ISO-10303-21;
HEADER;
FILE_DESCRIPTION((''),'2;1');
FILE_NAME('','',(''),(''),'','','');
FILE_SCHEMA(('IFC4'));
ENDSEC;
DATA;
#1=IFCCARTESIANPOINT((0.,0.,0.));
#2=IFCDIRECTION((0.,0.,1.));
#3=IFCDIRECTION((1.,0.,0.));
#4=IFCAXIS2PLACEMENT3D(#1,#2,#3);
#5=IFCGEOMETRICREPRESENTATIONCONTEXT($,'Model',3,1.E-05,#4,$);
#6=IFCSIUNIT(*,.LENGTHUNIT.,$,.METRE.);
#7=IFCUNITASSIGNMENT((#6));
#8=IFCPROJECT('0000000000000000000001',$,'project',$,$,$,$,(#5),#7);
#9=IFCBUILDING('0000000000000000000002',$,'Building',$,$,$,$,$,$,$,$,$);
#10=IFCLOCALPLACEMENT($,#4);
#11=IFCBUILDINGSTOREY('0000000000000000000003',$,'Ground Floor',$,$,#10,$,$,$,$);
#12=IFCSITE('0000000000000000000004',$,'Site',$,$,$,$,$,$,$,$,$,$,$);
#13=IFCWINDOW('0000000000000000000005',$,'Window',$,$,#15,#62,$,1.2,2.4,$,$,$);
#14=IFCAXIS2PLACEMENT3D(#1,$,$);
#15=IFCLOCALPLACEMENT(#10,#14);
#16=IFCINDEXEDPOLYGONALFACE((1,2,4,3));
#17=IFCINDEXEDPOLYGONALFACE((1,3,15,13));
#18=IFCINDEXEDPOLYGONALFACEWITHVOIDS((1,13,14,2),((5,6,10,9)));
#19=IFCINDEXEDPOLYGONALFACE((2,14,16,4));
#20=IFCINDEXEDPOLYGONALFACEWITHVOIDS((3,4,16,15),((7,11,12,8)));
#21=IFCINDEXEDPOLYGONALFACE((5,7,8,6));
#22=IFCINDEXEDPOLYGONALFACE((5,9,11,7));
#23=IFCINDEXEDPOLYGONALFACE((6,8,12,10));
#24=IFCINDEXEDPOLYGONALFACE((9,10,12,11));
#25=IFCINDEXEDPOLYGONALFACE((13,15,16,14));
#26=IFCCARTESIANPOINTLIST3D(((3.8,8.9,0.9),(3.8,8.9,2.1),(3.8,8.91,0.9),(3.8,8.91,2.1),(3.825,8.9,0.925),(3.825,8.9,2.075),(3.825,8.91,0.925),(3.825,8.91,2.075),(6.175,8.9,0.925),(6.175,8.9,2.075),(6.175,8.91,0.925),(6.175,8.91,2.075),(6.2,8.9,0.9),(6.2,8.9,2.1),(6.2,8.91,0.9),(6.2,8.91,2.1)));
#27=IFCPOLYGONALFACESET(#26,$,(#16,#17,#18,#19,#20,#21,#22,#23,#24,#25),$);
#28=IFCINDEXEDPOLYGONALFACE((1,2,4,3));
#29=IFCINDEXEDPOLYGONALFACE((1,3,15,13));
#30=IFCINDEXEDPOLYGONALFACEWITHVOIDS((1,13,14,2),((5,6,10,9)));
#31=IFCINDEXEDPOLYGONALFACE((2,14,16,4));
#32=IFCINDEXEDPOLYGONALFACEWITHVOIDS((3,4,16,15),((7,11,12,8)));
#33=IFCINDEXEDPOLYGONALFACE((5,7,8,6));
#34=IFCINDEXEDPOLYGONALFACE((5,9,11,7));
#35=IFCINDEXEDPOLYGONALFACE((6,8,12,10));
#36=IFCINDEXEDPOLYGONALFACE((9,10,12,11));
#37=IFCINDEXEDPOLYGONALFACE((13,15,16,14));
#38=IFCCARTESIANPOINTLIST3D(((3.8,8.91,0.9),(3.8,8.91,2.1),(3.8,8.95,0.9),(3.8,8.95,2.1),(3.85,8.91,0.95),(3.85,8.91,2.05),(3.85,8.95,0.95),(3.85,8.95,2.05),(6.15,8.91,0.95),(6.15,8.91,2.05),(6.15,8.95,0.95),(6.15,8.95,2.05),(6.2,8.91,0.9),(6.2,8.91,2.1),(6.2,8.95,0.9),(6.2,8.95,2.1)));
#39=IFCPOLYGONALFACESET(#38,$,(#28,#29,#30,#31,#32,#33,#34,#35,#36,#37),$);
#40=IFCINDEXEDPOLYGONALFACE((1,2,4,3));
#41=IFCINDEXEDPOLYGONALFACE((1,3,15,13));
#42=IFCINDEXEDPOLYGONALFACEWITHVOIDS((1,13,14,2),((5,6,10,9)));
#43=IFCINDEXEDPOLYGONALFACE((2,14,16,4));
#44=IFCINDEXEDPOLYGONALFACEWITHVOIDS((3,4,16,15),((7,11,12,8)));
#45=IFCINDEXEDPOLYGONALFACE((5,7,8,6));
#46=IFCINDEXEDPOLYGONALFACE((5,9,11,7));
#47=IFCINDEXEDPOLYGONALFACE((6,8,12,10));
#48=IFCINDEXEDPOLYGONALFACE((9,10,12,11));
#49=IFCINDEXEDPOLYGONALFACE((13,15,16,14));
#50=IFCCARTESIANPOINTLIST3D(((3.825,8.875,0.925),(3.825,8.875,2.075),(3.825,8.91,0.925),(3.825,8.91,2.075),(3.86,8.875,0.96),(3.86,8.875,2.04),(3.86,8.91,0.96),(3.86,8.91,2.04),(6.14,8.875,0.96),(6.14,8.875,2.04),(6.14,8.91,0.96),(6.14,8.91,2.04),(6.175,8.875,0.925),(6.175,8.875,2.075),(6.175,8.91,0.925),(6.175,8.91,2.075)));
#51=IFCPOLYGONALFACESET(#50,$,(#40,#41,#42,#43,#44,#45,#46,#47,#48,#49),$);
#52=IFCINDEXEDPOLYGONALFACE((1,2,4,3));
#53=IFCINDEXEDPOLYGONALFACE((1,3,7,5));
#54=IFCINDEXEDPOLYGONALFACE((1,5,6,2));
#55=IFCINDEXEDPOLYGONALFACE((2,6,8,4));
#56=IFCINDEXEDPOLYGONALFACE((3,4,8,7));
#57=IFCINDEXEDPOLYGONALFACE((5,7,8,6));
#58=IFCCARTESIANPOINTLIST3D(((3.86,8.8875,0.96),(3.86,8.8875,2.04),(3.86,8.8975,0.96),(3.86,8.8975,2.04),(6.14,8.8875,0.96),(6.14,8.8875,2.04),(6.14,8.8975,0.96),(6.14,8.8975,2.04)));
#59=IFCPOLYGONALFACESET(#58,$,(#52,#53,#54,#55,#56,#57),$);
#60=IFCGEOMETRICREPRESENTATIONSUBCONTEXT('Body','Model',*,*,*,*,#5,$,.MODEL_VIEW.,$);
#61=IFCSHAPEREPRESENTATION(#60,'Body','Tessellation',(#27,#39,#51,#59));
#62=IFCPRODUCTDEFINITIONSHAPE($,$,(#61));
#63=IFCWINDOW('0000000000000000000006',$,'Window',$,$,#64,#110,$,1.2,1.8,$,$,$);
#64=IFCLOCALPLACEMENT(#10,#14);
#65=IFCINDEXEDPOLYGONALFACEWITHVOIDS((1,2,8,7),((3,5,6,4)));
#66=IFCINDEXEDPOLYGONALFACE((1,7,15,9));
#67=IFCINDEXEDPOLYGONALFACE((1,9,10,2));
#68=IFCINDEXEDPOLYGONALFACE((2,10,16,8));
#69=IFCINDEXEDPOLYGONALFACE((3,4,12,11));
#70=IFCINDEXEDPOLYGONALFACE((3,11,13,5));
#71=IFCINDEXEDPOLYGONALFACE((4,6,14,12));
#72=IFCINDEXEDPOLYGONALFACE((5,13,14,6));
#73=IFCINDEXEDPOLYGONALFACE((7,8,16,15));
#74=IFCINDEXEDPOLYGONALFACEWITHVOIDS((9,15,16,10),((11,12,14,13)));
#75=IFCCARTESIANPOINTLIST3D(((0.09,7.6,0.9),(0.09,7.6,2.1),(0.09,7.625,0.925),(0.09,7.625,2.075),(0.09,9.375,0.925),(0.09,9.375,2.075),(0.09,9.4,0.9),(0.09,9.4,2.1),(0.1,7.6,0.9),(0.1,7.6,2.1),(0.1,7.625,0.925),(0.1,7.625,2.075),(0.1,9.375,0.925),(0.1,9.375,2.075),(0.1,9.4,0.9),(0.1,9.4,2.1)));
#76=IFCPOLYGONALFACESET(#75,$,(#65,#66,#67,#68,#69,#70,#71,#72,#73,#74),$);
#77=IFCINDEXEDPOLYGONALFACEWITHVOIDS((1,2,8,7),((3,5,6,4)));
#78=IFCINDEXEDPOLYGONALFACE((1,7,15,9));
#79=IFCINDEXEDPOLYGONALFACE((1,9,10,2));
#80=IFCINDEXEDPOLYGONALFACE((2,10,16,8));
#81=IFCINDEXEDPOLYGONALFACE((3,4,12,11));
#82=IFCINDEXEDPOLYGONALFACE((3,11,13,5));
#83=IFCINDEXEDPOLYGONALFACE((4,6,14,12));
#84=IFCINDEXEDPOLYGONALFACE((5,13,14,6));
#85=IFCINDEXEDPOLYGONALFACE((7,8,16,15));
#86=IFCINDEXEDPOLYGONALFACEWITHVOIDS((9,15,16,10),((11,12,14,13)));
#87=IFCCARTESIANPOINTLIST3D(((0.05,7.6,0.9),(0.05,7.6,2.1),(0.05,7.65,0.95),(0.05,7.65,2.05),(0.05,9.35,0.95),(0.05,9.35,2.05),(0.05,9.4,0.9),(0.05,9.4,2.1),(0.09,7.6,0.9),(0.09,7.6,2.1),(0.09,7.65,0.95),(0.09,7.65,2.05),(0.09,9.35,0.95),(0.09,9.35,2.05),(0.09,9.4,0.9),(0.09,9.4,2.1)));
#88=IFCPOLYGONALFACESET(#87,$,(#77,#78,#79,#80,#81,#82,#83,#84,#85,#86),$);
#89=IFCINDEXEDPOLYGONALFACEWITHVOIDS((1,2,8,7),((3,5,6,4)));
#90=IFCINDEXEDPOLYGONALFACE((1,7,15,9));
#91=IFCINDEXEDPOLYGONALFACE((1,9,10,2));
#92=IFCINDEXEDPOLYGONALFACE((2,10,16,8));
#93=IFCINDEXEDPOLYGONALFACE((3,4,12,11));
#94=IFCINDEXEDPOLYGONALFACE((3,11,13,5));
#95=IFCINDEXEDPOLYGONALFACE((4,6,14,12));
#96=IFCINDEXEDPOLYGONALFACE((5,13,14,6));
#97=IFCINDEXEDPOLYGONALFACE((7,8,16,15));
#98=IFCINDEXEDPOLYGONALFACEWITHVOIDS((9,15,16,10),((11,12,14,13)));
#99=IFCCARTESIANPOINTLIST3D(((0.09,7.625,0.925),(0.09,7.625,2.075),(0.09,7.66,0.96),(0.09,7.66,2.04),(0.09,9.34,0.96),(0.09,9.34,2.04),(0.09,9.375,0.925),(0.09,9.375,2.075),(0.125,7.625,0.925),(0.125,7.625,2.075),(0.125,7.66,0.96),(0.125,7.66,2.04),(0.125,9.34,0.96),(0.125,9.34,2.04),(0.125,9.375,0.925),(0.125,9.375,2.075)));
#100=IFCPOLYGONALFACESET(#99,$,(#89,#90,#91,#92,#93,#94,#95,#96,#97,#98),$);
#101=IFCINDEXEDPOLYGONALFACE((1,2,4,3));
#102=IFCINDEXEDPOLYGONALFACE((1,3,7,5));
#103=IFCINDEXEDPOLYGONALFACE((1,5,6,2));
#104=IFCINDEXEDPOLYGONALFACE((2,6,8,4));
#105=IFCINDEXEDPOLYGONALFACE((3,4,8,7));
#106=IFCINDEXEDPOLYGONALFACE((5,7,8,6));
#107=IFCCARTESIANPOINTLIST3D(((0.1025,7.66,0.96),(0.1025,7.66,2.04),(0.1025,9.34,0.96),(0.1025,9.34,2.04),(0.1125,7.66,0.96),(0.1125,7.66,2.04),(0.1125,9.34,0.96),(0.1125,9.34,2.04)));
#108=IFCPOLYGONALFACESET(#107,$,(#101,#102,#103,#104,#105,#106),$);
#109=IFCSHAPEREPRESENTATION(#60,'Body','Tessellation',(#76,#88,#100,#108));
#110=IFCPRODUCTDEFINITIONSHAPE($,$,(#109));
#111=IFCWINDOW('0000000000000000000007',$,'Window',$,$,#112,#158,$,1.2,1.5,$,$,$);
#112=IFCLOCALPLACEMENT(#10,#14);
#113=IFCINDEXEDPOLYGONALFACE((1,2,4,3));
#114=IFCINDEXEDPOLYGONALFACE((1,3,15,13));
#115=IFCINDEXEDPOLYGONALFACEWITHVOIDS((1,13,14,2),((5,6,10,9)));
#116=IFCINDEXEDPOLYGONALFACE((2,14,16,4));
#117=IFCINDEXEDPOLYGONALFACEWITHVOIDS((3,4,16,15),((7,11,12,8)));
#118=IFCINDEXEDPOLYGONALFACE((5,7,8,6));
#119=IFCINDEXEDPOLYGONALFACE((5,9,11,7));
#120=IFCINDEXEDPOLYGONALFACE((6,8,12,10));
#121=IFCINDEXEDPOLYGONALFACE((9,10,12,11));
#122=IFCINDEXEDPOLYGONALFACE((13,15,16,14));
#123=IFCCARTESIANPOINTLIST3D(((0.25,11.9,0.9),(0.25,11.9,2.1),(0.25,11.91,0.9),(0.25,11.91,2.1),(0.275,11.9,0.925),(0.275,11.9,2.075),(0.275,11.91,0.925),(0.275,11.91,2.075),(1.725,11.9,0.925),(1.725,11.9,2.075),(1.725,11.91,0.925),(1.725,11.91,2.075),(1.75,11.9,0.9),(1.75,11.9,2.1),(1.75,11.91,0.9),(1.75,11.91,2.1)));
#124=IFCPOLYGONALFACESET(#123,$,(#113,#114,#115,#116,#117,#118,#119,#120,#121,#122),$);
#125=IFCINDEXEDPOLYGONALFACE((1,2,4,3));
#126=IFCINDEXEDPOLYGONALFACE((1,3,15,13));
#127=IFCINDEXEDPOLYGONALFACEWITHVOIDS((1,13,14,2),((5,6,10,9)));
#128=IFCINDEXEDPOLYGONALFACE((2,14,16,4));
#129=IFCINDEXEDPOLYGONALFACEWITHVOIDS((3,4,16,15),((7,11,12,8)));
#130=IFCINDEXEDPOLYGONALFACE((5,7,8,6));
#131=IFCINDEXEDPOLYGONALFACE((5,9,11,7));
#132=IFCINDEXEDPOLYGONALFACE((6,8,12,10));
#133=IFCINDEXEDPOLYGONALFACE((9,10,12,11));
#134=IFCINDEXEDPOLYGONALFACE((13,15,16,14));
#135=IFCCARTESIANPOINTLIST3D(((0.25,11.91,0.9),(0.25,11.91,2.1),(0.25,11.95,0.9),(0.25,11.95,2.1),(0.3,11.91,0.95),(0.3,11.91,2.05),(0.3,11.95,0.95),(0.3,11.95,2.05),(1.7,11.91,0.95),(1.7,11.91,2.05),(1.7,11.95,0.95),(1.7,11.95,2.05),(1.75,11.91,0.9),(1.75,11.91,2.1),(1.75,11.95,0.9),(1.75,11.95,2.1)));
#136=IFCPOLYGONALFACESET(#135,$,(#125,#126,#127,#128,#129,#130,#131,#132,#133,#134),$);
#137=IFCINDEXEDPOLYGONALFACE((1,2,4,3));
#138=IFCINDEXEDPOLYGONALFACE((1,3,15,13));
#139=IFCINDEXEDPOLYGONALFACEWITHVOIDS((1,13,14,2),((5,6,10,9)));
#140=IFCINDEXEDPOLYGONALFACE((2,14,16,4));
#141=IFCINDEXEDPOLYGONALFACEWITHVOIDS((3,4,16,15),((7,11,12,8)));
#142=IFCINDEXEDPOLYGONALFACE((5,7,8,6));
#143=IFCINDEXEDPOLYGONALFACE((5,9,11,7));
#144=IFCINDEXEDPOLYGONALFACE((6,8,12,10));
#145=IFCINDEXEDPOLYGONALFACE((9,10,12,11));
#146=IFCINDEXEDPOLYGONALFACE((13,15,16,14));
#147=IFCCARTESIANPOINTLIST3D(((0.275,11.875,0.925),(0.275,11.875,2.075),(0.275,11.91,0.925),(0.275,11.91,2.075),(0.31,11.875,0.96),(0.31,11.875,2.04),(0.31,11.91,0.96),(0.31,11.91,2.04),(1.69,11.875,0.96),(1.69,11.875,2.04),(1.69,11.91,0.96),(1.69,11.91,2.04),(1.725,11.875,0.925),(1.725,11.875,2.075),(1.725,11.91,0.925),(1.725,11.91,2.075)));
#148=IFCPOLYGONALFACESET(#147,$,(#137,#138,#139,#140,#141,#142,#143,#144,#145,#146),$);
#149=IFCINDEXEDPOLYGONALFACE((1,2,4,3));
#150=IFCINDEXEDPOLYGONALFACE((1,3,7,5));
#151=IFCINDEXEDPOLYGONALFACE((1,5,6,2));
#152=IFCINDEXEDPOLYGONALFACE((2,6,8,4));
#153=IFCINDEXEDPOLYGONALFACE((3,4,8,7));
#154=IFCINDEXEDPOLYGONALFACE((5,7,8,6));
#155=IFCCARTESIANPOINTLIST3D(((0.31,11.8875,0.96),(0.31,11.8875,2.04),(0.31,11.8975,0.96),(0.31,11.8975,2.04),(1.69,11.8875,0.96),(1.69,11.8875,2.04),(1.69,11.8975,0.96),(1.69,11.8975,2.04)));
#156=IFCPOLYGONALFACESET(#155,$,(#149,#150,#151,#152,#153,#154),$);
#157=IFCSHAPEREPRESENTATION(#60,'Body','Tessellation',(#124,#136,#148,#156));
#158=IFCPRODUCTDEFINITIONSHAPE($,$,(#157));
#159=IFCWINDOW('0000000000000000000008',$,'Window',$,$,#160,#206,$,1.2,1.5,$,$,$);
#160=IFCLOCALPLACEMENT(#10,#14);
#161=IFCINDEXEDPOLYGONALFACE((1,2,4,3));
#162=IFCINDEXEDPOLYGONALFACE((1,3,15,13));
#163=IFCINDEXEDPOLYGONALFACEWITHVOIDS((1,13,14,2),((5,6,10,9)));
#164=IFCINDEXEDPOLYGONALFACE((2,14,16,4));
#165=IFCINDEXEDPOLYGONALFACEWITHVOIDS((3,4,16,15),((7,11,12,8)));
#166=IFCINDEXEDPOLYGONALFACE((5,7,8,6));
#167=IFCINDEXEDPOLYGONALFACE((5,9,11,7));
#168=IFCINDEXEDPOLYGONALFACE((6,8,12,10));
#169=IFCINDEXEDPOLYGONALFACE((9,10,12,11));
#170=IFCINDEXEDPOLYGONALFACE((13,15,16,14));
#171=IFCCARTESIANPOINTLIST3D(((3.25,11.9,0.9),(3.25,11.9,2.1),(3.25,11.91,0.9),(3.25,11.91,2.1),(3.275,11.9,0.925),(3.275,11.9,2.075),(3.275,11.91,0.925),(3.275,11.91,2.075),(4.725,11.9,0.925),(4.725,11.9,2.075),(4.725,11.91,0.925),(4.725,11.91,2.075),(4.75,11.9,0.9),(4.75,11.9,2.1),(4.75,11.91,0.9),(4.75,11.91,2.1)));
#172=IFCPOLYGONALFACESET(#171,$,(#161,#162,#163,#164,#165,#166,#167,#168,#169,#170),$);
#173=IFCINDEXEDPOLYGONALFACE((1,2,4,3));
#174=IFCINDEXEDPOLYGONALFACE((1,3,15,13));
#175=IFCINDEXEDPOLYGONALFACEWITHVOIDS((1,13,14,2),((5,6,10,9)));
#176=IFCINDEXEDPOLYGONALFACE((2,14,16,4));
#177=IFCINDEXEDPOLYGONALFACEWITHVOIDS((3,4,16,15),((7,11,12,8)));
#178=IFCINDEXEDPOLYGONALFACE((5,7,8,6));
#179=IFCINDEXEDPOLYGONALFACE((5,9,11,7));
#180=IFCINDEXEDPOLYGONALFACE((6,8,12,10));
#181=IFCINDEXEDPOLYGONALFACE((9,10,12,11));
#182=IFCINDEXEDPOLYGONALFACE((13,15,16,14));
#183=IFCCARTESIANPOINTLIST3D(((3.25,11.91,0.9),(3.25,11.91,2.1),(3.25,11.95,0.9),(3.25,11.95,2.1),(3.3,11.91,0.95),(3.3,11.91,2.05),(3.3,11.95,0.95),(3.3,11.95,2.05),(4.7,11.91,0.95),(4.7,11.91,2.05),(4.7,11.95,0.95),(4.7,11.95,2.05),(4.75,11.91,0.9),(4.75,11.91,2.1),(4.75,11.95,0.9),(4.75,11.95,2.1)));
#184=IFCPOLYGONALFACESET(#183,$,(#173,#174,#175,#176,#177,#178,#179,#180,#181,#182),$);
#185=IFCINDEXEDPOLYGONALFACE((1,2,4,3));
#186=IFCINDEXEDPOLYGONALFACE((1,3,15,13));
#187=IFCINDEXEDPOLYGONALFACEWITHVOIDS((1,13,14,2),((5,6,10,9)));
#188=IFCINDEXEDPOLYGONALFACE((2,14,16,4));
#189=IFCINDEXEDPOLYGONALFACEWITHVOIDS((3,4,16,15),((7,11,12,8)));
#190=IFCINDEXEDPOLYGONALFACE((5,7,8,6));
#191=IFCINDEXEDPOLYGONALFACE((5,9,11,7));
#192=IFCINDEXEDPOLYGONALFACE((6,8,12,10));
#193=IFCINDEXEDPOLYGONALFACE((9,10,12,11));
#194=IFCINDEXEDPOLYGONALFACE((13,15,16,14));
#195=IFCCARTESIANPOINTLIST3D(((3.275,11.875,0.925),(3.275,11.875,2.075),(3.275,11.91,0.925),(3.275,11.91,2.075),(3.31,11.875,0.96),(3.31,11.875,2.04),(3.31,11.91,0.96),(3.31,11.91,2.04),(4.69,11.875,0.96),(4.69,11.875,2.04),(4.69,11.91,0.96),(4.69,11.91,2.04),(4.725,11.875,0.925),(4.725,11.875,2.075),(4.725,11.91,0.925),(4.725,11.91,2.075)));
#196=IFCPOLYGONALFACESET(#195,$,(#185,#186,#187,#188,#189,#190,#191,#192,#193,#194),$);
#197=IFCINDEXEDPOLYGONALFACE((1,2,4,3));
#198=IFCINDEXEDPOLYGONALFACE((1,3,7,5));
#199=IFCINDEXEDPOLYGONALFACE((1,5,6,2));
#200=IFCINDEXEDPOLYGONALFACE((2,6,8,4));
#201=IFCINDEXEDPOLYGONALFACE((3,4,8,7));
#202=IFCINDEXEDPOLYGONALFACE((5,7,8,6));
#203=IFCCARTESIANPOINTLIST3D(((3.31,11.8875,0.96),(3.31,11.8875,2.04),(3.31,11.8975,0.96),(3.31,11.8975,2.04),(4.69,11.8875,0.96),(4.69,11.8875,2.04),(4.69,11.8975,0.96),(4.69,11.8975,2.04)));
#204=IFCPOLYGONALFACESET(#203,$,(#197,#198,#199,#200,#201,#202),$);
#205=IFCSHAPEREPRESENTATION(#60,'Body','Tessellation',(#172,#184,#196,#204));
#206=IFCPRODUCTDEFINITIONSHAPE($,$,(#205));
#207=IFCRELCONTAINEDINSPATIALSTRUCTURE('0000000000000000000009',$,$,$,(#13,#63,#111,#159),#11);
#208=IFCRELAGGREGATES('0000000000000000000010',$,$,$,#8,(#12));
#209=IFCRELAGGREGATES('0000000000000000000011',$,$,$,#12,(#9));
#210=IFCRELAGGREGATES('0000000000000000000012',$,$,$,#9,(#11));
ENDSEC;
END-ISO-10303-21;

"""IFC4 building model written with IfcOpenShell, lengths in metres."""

from ifc_helpers import new_model, si_unit, frame, origin_with_axes, place, context, subcontext, project, spatial, line, indexed_curve, outline, extrude, element, save


model = new_model("IFC4")

# Units and contexts
model_context = context("Model", 3, precision=1e-05, world=origin_with_axes())
body_context = subcontext(model_context, "Body", "Model", "MODEL_VIEW")
ifc_project = project(units=[si_unit("LENGTHUNIT", "METRE")], contexts=[model_context])

# Site, building, storey
site = spatial("IfcSite", under=ifc_project, Name="Site")
building = spatial("IfcBuilding", under=site, Name="Building")
storey_placement = place(None, origin_with_axes())
storey = spatial("IfcBuildingStorey", under=building, at=storey_placement, Name="Ground Floor")

# Windows
window_1_placement = place(storey_placement, frame((6.2, 9.0, 0.9), z_axis=(0.0, 0.0, 1.0), x_axis=(-1.0, 0.0, 0.0)))
element("IfcWindow", 1, at=window_1_placement, inside=storey, Name="Window", OverallHeight=1.2, OverallWidth=2.4, context=body_context, shape_type="SweptSolid", body=[
    extrude(outline(indexed_curve([(0.0, 0.0), (2.4, 0.0), (2.4, 1.2), (0.0, 1.2)], segments=[line(1, 2, 3, 4, 1)]), holes=[indexed_curve([(0.025, 0.025), (2.375, 0.025), (2.375, 1.175), (0.025, 1.175)], segments=[line(1, 2, 3, 4, 1)])]), frame((0.0, 0.09, 0.0), z_axis=(0.0, -1.0, 0.0), x_axis=(1.0, 0.0, 0.0)), (0.0, 0.0, -1.0), 0.01),
    extrude(outline(indexed_curve([(0.0, 0.0), (2.4, 0.0), (2.4, 1.2), (0.0, 1.2)], segments=[line(1, 2, 3, 4, 1)]), holes=[indexed_curve([(0.05, 0.05), (2.35, 0.05), (2.35, 1.15), (0.05, 1.15)], segments=[line(1, 2, 3, 4, 1)])]), frame((0.0, 0.05, 0.0), z_axis=(0.0, -1.0, 0.0), x_axis=(1.0, 0.0, 0.0)), (0.0, 0.0, -1.0), 0.04),
    extrude(outline(indexed_curve([(0.0, 0.0), (2.35, 0.0), (2.35, 1.15), (0.0, 1.15)], segments=[line(1, 2, 3, 4, 1)]), holes=[indexed_curve([(0.035, 0.035), (2.315, 0.035), (2.315, 1.115), (0.035, 1.115)], segments=[line(1, 2, 3, 4, 1)])]), frame((0.025, 0.09, 0.025), z_axis=(0.0, -1.0, 0.0), x_axis=(1.0, 0.0, 0.0)), (0.0, 0.0, -1.0), 0.035),
    extrude(outline(indexed_curve([(0.035, 0.035), (2.315, 0.035), (2.315, 1.115), (0.035, 1.115)], segments=[line(1, 2, 3, 4, 1)])), frame((0.025, 0.1025, 0.025), z_axis=(0.0, -1.0, 0.0), x_axis=(1.0, 0.0, 0.0)), (0.0, 0.0, -1.0), 0.01),
])
window_2_placement = place(storey_placement, frame((0.0, 9.4, 0.9), z_axis=(0.0, 0.0, 1.0), x_axis=(0.0, -1.0, 0.0)))
element("IfcWindow", 2, at=window_2_placement, inside=storey, Name="Window", OverallHeight=1.2, OverallWidth=1.8, context=body_context, shape_type="SweptSolid", body=[
    extrude(outline(indexed_curve([(0.0, 0.0), (1.8, 0.0), (1.8, 1.2), (0.0, 1.2)], segments=[line(1, 2, 3, 4, 1)]), holes=[indexed_curve([(0.025, 0.025), (1.775, 0.025), (1.775, 1.175), (0.025, 1.175)], segments=[line(1, 2, 3, 4, 1)])]), frame((0.0, 0.09, 0.0), z_axis=(0.0, -1.0, 0.0), x_axis=(1.0, 0.0, 0.0)), (0.0, 0.0, -1.0), 0.01),
    extrude(outline(indexed_curve([(0.0, 0.0), (1.8, 0.0), (1.8, 1.2), (0.0, 1.2)], segments=[line(1, 2, 3, 4, 1)]), holes=[indexed_curve([(0.05, 0.05), (1.75, 0.05), (1.75, 1.15), (0.05, 1.15)], segments=[line(1, 2, 3, 4, 1)])]), frame((0.0, 0.05, 0.0), z_axis=(0.0, -1.0, 0.0), x_axis=(1.0, 0.0, 0.0)), (0.0, 0.0, -1.0), 0.04),
    extrude(outline(indexed_curve([(0.0, 0.0), (1.75, 0.0), (1.75, 1.15), (0.0, 1.15)], segments=[line(1, 2, 3, 4, 1)]), holes=[indexed_curve([(0.035, 0.035), (1.715, 0.035), (1.715, 1.115), (0.035, 1.115)], segments=[line(1, 2, 3, 4, 1)])]), frame((0.025, 0.09, 0.025), z_axis=(0.0, -1.0, 0.0), x_axis=(1.0, 0.0, 0.0)), (0.0, 0.0, -1.0), 0.035),
    extrude(outline(indexed_curve([(0.035, 0.035), (1.715, 0.035), (1.715, 1.115), (0.035, 1.115)], segments=[line(1, 2, 3, 4, 1)])), frame((0.025, 0.1025, 0.025), z_axis=(0.0, -1.0, 0.0), x_axis=(1.0, 0.0, 0.0)), (0.0, 0.0, -1.0), 0.01),
])
for number, where, z_axis, x_axis, name in (
    (3, (1.75, 12.0, 0.9), (0.0, 0.0, 1.0), (-1.0, 0.0, 0.0), "Window"),
    (4, (4.75, 12.0, 0.9), (0.0, 0.0, 1.0), (-1.0, 0.0, 0.0), "Window"),
):
    element("IfcWindow", number, at=place(storey_placement, frame(where, z_axis=z_axis, x_axis=x_axis)), inside=storey, Name=name, OverallHeight=1.2, OverallWidth=1.5, context=body_context, shape_type="SweptSolid", body=[
        extrude(outline(indexed_curve([(0.0, 0.0), (1.5, 0.0), (1.5, 1.2), (0.0, 1.2)], segments=[line(1, 2, 3, 4, 1)]), holes=[indexed_curve([(0.025, 0.025), (1.475, 0.025), (1.475, 1.175), (0.025, 1.175)], segments=[line(1, 2, 3, 4, 1)])]), frame((0.0, 0.09, 0.0), z_axis=(0.0, -1.0, 0.0), x_axis=(1.0, 0.0, 0.0)), (0.0, 0.0, -1.0), 0.01),
        extrude(outline(indexed_curve([(0.0, 0.0), (1.5, 0.0), (1.5, 1.2), (0.0, 1.2)], segments=[line(1, 2, 3, 4, 1)]), holes=[indexed_curve([(0.05, 0.05), (1.45, 0.05), (1.45, 1.15), (0.05, 1.15)], segments=[line(1, 2, 3, 4, 1)])]), frame((0.0, 0.05, 0.0), z_axis=(0.0, -1.0, 0.0), x_axis=(1.0, 0.0, 0.0)), (0.0, 0.0, -1.0), 0.04),
        extrude(outline(indexed_curve([(0.0, 0.0), (1.45, 0.0), (1.45, 1.15), (0.0, 1.15)], segments=[line(1, 2, 3, 4, 1)]), holes=[indexed_curve([(0.035, 0.035), (1.415, 0.035), (1.415, 1.115), (0.035, 1.115)], segments=[line(1, 2, 3, 4, 1)])]), frame((0.025, 0.09, 0.025), z_axis=(0.0, -1.0, 0.0), x_axis=(1.0, 0.0, 0.0)), (0.0, 0.0, -1.0), 0.035),
        extrude(outline(indexed_curve([(0.035, 0.035), (1.415, 0.035), (1.415, 1.115), (0.035, 1.115)], segments=[line(1, 2, 3, 4, 1)])), frame((0.025, 0.1025, 0.025), z_axis=(0.0, -1.0, 0.0), x_axis=(1.0, 0.0, 0.0)), (0.0, 0.0, -1.0), 0.01),
    ])

save(model, "model.ifc")
